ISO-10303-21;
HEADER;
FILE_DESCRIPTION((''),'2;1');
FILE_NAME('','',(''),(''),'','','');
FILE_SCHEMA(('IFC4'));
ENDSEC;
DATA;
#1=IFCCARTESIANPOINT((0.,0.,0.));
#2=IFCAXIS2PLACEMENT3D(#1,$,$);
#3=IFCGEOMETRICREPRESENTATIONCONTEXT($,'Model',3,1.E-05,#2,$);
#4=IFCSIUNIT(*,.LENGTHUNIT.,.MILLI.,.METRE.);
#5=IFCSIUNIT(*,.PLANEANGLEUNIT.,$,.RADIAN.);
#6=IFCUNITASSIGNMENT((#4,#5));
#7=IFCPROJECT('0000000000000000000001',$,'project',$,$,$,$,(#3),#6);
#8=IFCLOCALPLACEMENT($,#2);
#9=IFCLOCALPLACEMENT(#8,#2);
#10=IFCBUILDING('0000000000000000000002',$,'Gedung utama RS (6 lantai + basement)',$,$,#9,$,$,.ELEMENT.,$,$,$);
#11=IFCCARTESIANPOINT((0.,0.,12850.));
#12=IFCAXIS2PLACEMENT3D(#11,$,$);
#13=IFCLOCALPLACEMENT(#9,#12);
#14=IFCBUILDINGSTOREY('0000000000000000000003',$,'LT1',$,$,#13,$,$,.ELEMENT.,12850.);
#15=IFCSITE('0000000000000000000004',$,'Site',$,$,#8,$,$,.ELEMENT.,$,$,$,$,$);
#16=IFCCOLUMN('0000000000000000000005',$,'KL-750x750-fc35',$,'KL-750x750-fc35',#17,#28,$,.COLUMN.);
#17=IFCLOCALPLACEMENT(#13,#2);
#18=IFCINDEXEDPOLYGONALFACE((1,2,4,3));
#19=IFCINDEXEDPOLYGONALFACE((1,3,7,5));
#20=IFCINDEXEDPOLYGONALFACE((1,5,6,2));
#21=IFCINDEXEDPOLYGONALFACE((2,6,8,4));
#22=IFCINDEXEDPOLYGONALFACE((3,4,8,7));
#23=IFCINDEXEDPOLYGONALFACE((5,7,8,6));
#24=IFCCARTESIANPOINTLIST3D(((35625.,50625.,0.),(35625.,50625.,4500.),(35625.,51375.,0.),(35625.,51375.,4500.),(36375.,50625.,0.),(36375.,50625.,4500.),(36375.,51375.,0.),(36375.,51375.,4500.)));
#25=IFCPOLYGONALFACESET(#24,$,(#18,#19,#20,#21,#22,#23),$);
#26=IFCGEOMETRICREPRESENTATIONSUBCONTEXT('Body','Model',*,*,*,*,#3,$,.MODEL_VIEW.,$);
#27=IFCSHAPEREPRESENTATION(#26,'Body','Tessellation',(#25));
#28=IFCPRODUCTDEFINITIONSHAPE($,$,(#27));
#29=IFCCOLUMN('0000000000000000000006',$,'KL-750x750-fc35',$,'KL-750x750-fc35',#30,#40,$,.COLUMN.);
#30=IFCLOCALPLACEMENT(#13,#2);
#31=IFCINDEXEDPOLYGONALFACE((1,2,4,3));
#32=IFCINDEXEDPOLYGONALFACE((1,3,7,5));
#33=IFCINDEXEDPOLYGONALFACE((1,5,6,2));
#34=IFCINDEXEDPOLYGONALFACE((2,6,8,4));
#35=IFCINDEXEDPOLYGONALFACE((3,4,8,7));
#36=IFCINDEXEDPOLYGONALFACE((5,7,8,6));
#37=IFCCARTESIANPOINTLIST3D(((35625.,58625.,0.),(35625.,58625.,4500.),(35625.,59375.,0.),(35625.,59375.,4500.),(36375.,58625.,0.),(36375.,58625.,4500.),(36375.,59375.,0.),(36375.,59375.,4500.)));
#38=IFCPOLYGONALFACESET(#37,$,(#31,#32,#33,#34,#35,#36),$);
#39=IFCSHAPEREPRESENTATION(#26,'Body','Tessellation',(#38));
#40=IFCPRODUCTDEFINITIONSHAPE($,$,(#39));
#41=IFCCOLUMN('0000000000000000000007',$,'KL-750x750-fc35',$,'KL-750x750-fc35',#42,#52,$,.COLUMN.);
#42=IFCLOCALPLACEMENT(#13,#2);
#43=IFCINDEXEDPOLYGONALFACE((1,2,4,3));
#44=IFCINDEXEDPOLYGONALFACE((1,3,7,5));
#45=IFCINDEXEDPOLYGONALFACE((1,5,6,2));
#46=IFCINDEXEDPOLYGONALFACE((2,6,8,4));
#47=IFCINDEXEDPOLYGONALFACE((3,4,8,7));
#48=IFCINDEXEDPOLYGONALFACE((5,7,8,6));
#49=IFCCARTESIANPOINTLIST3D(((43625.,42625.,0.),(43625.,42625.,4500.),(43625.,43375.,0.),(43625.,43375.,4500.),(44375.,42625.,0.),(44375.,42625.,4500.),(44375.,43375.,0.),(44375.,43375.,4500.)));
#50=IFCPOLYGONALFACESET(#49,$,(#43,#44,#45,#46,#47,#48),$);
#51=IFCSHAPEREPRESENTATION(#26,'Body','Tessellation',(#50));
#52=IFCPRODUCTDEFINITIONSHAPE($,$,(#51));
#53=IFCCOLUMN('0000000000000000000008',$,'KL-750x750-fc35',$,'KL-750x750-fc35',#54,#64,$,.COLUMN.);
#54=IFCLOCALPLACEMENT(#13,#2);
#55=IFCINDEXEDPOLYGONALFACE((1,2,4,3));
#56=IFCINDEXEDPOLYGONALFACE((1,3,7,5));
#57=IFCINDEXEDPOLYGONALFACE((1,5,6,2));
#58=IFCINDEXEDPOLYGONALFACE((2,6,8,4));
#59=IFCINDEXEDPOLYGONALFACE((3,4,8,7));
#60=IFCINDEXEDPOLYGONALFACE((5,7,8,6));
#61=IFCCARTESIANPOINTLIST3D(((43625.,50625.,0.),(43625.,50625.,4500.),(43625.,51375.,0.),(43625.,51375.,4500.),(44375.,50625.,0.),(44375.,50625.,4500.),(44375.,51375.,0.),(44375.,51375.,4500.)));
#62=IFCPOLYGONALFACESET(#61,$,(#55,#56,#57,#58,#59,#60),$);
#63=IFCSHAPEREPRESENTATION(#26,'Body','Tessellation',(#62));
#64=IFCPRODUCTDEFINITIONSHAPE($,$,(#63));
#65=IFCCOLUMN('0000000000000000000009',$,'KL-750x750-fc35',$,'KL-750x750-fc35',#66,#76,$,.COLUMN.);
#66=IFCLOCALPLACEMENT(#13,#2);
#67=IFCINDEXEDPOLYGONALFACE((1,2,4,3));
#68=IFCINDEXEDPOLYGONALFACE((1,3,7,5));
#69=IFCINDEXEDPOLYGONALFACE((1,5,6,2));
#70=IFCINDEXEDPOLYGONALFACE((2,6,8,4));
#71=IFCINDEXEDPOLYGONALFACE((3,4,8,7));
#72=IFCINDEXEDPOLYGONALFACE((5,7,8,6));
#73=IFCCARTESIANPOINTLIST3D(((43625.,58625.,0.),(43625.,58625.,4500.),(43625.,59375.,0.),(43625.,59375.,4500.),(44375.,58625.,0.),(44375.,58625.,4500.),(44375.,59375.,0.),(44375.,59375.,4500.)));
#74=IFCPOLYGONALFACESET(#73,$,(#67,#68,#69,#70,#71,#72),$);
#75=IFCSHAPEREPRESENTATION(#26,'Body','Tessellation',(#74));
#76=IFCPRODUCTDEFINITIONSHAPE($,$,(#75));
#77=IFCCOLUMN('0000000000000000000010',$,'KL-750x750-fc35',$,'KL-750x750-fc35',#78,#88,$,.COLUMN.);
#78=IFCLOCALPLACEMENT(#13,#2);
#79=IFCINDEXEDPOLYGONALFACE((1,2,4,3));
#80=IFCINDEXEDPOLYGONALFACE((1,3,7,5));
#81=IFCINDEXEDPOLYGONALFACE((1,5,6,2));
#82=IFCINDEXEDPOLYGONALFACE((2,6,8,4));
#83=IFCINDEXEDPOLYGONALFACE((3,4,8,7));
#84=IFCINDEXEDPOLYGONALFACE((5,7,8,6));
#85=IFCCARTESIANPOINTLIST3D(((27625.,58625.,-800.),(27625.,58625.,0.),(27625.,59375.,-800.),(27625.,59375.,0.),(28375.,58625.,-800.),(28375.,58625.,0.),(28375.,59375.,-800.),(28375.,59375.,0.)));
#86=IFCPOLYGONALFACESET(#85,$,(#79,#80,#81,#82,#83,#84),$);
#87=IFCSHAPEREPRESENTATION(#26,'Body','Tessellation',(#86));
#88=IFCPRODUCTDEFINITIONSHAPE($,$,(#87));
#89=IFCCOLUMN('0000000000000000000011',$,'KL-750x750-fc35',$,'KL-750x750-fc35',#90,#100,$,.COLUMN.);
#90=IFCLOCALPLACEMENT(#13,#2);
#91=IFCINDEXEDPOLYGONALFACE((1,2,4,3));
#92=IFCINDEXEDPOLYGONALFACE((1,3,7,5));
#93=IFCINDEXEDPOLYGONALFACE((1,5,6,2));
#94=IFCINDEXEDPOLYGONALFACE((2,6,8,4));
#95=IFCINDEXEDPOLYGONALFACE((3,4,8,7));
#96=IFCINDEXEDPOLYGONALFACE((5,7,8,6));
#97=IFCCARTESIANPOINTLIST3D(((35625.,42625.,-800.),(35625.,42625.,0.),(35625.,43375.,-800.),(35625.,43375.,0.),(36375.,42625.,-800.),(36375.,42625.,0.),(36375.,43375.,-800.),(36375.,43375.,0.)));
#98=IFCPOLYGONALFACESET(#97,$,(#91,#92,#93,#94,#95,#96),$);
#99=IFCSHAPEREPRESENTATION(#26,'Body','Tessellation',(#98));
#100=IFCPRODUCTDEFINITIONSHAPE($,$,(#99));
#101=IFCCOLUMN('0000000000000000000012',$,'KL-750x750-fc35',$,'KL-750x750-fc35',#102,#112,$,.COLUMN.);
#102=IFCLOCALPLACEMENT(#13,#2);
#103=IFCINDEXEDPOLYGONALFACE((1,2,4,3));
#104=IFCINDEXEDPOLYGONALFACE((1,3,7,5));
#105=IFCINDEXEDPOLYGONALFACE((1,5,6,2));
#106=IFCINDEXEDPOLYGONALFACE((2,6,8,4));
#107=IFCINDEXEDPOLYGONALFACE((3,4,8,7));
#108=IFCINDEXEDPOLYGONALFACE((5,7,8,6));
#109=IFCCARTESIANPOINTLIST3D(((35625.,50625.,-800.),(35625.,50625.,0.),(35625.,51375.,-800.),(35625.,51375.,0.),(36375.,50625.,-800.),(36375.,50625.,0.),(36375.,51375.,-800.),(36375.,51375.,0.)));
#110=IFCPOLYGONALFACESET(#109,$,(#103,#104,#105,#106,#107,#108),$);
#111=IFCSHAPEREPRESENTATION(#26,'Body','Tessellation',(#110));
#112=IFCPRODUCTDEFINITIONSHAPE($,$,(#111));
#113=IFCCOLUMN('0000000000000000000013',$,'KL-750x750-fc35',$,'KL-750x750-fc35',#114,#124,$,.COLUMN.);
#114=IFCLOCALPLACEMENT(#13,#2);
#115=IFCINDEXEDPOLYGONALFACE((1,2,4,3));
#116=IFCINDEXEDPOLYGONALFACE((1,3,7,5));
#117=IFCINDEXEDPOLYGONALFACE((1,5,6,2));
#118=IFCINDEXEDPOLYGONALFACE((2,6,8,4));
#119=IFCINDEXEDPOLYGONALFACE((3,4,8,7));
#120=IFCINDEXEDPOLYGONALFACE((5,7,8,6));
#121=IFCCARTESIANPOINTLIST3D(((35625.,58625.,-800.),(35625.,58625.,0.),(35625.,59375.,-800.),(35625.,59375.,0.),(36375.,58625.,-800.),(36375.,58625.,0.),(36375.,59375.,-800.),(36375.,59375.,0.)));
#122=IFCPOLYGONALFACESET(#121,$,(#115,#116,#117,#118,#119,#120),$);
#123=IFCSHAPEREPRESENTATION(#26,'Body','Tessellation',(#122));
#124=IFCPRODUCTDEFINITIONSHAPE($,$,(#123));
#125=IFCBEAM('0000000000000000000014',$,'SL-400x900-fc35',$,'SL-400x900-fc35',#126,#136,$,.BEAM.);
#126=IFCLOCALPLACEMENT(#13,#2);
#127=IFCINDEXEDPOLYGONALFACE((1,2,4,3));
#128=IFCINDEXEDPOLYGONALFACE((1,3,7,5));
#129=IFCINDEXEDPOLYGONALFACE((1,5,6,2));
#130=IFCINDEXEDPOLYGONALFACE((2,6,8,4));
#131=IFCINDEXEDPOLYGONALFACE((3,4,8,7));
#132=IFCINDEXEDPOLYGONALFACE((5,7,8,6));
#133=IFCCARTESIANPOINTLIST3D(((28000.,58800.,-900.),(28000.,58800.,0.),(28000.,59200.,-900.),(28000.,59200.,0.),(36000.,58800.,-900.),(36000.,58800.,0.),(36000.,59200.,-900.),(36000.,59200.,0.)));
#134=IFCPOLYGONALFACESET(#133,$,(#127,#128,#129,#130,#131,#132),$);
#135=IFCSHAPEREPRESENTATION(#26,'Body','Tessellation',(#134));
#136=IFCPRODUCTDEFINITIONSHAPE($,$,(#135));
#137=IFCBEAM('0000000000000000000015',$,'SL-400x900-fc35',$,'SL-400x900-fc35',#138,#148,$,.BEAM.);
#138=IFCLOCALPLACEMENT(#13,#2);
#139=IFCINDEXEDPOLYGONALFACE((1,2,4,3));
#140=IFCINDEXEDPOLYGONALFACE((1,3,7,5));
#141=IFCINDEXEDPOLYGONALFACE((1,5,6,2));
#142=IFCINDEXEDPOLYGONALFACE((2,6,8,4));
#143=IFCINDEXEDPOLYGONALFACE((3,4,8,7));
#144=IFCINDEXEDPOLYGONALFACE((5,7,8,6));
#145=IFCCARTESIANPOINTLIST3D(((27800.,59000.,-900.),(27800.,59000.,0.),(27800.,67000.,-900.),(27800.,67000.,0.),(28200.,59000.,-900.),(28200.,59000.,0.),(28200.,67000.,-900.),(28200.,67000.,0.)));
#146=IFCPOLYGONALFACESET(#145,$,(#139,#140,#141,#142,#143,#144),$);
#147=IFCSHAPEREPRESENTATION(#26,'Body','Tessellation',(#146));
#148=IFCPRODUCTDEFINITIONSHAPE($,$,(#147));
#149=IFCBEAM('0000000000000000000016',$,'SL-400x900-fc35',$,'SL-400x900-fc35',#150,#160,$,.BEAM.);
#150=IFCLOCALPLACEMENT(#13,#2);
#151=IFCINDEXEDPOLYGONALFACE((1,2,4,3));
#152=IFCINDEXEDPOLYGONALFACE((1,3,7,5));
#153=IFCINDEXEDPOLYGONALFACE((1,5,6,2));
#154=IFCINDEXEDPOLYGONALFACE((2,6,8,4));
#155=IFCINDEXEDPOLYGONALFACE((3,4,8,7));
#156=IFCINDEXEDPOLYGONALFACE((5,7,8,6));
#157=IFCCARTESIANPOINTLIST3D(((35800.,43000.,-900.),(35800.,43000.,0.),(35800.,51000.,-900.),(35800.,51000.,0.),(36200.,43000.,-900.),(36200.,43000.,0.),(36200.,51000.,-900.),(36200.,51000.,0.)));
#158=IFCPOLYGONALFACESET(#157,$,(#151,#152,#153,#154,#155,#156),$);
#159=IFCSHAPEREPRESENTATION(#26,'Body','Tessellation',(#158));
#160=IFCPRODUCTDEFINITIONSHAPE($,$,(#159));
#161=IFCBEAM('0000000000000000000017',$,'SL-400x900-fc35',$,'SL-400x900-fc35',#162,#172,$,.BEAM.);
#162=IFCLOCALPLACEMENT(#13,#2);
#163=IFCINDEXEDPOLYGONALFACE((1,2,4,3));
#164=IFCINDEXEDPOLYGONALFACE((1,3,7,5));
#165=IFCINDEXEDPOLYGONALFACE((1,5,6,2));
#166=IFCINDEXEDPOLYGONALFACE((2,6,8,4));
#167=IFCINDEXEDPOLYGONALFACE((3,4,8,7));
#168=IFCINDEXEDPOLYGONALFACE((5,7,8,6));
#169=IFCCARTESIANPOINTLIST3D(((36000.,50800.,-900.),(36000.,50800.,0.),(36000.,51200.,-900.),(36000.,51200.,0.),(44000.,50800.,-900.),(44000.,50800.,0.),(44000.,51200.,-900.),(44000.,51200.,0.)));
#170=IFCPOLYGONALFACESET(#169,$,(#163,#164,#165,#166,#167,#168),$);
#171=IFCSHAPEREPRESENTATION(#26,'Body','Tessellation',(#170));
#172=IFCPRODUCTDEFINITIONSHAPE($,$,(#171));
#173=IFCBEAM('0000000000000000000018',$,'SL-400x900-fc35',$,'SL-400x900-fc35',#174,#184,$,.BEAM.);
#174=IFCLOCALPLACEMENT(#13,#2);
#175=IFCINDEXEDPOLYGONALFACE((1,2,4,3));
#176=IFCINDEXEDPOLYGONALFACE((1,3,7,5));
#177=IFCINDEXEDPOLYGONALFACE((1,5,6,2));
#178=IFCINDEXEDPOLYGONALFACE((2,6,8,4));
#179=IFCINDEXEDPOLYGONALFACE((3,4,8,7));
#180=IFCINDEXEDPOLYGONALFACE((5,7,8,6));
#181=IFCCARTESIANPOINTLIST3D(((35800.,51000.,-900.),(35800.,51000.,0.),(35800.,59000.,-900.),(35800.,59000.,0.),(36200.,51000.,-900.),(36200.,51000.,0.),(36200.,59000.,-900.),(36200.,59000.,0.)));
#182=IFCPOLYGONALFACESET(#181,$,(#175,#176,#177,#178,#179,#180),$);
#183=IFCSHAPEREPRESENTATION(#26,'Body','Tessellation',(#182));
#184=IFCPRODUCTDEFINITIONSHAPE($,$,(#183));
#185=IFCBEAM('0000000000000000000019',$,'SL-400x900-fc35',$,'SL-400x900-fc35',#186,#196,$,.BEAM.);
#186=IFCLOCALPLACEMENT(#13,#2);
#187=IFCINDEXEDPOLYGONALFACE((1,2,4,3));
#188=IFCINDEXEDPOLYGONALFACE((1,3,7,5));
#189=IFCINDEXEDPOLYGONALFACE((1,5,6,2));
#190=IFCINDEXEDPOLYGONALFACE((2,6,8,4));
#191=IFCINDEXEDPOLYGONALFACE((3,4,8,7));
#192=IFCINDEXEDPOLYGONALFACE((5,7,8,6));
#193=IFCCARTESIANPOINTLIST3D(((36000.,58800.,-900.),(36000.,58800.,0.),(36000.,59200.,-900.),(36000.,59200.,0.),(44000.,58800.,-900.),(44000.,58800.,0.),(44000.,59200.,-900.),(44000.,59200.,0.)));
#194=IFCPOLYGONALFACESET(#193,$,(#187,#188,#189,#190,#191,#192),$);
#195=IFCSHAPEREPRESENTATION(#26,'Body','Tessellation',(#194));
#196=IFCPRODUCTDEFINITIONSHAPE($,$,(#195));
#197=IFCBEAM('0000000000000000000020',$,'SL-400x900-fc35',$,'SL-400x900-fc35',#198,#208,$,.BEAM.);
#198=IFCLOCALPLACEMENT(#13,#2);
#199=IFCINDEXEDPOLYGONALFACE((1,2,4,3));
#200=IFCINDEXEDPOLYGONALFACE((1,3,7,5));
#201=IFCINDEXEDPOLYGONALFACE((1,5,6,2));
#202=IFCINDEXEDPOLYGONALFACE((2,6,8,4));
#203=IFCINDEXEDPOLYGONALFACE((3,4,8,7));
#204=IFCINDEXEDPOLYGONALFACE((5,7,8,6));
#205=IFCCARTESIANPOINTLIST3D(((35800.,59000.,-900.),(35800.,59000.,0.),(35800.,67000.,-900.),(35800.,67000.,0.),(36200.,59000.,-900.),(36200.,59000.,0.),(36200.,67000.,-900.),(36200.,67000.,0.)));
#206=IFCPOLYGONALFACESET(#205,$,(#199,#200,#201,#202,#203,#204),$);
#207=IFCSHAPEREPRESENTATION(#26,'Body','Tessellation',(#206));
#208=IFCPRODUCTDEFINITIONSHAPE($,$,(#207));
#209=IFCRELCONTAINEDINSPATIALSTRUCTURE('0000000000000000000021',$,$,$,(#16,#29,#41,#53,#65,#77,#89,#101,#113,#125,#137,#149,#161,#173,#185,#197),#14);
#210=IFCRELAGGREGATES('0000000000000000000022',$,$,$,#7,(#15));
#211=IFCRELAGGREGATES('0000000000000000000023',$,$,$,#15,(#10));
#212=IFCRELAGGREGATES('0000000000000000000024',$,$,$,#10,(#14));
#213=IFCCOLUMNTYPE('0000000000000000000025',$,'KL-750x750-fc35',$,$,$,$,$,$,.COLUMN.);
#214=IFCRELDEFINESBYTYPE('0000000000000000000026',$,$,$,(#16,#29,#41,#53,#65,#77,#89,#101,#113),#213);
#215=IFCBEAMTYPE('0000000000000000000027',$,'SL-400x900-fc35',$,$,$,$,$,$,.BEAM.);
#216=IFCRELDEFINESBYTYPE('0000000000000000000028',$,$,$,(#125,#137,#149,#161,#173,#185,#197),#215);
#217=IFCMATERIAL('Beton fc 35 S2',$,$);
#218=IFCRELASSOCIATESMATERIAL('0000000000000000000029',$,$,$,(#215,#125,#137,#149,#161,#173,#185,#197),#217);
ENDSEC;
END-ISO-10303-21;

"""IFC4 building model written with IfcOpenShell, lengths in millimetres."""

from ifc_helpers import new_model, si_unit, frame, origin, origin_2d, place, context, subcontext, project, spatial, rectangle, extrude, material, material_profile, profile_set, profile_usage, type_object, element, save


model = new_model("IFC4")

# Units and contexts
model_context = context("Model", 3, precision=1e-05, world=origin())
body_context = subcontext(model_context, "Body", "Model", "MODEL_VIEW")
ifc_project = project(units=[si_unit("LENGTHUNIT", "METRE", prefix="MILLI"), si_unit("PLANEANGLEUNIT", "RADIAN")], contexts=[model_context])

# Site, building, storey
site_placement = place(None, origin())
site = spatial("IfcSite", under=ifc_project, at=site_placement, Name="Site", CompositionType="ELEMENT")
building_placement = place(site_placement, origin())
building = spatial("IfcBuilding", under=site, at=building_placement, Name="Gedung utama RS (6 lantai + basement)", CompositionType="ELEMENT")
storey_placement = place(building_placement, frame((0.0, 0.0, 12850.0)))
storey = spatial("IfcBuildingStorey", under=building, at=storey_placement, Name="LT1", CompositionType="ELEMENT", Elevation=12850.0)

# Columns
ifc_material_profile_1 = material_profile(None, rectangle(XDim=750.0, YDim=750.0, at=origin_2d()), Name="KL-750x750-fc35")
ifc_profile_set_1 = profile_set([ifc_material_profile_1], Name="KL-750x750-fc35")
ifc_profile_usage_1 = profile_usage(ifc_profile_set_1, cardinal=5)
column_type = type_object("IfcColumnType", Name="KL-750x750-fc35", PredefinedType="COLUMN", material=ifc_profile_set_1)
for number, where, z_axis, x_axis, name in (
    (1, (36000.0, 51000.0, 0.0), (0.0, 0.0, 1.0), (1.0, 0.0, 0.0), "KL-750x750-fc35"),
    (2, (36000.0, 59000.0, 0.0), (0.0, 0.0, 1.0), (1.0, 0.0, 0.0), "KL-750x750-fc35"),
    (3, (44000.0, 43000.0, 0.0), (0.0, 0.0, 1.0), (1.0, 0.0, 0.0), "KL-750x750-fc35"),
    (4, (44000.0, 51000.0, 0.0), (0.0, 0.0, 1.0), (1.0, 0.0, 0.0), "KL-750x750-fc35"),
    (5, (44000.0, 59000.0, 0.0), (0.0, 0.0, 1.0), (1.0, 0.0, 0.0), "KL-750x750-fc35"),
):
    element("IfcColumn", number, at=place(storey_placement, frame(where, z_axis=z_axis, x_axis=x_axis)), inside=storey, type_object=column_type, material=ifc_profile_usage_1, Name=name, ObjectType="KL-750x750-fc35", PredefinedType="COLUMN", context=body_context, shape_type="SweptSolid", body=[
        extrude(rectangle(XDim=750.0, YDim=750.0, at=origin_2d()), origin(), (0.0, 0.0, 1.0), 4500.0),
    ])
for number, where, z_axis, x_axis, name in (
    (6, (28000.0, 59000.0, -800.0), (0.0, 0.0, 1.0), (1.0, 0.0, 0.0), "KL-750x750-fc35"),
    (7, (36000.0, 43000.0, -800.0), (0.0, 0.0, 1.0), (1.0, 0.0, 0.0), "KL-750x750-fc35"),
    (8, (36000.0, 51000.0, -800.0), (0.0, 0.0, 1.0), (1.0, 0.0, 0.0), "KL-750x750-fc35"),
    (9, (36000.0, 59000.0, -800.0), (0.0, 0.0, 1.0), (1.0, 0.0, 0.0), "KL-750x750-fc35"),
):
    element("IfcColumn", number, at=place(storey_placement, frame(where, z_axis=z_axis, x_axis=x_axis)), inside=storey, type_object=column_type, material=ifc_profile_usage_1, Name=name, ObjectType="KL-750x750-fc35", PredefinedType="COLUMN", context=body_context, shape_type="SweptSolid", body=[
        extrude(rectangle(XDim=750.0, YDim=750.0, at=origin_2d()), origin(), (0.0, 0.0, 1.0), 800.0),
    ])

# Beams
ifc_material = material(Name="Beton fc 35 S2")
ifc_material_profile_2 = material_profile(ifc_material, rectangle(XDim=400.0, YDim=900.0, at=origin_2d()), Name="SL-400x900-fc35")
ifc_profile_set_2 = profile_set([ifc_material_profile_2], Name="SL-400x900-fc35")
ifc_profile_usage_2 = profile_usage(ifc_profile_set_2, cardinal=8)
beam_type = type_object("IfcBeamType", Name="SL-400x900-fc35", PredefinedType="BEAM", material=ifc_profile_set_2)
beam_1_placement = place(storey_placement, frame((28000.0, 59000.0, -450.0)))
element("IfcBeam", 10, at=beam_1_placement, inside=storey, type_object=beam_type, material=ifc_profile_usage_2, Name="SL-400x900-fc35", ObjectType="SL-400x900-fc35", PredefinedType="BEAM", context=body_context, shape_type="SweptSolid", body=[
    extrude(rectangle(XDim=400.0, YDim=900.0, at=origin_2d()), frame((0.0, 0.0, 0.0), z_axis=(1.0, 0.0, 0.0), x_axis=(0.0, 1.0, 0.0)), (0.0, 0.0, 1.0), 8000.0),
])
for number, where, name in (
    (11, (28000.0, 59000.0, -450.0), "SL-400x900-fc35"),
    (12, (36000.0, 43000.0, -450.0), "SL-400x900-fc35"),
):
    element("IfcBeam", number, at=place(storey_placement, frame(where)), inside=storey, type_object=beam_type, material=ifc_profile_usage_2, Name=name, ObjectType="SL-400x900-fc35", PredefinedType="BEAM", context=body_context, shape_type="SweptSolid", body=[
        extrude(rectangle(XDim=400.0, YDim=900.0, at=origin_2d()), frame((0.0, 0.0, 0.0), z_axis=(0.0, 1.0, 0.0), x_axis=(-1.0, 0.0, 0.0)), (0.0, 0.0, 1.0), 8000.0),
    ])
beam_2_placement = place(storey_placement, frame((36000.0, 51000.0, -450.0)))
element("IfcBeam", 13, at=beam_2_placement, inside=storey, type_object=beam_type, material=ifc_profile_usage_2, Name="SL-400x900-fc35", ObjectType="SL-400x900-fc35", PredefinedType="BEAM", context=body_context, shape_type="SweptSolid", body=[
    extrude(rectangle(XDim=400.0, YDim=900.0, at=origin_2d()), frame((0.0, 0.0, 0.0), z_axis=(1.0, 0.0, 0.0), x_axis=(0.0, 1.0, 0.0)), (0.0, 0.0, 1.0), 8000.0),
])
beam_3_placement = place(storey_placement, frame((36000.0, 51000.0, -450.0)))
element("IfcBeam", 14, at=beam_3_placement, inside=storey, type_object=beam_type, material=ifc_profile_usage_2, Name="SL-400x900-fc35", ObjectType="SL-400x900-fc35", PredefinedType="BEAM", context=body_context, shape_type="SweptSolid", body=[
    extrude(rectangle(XDim=400.0, YDim=900.0, at=origin_2d()), frame((0.0, 0.0, 0.0), z_axis=(0.0, 1.0, 0.0), x_axis=(-1.0, 0.0, 0.0)), (0.0, 0.0, 1.0), 8000.0),
])
beam_4_placement = place(storey_placement, frame((36000.0, 59000.0, -450.0)))
element("IfcBeam", 15, at=beam_4_placement, inside=storey, type_object=beam_type, material=ifc_profile_usage_2, Name="SL-400x900-fc35", ObjectType="SL-400x900-fc35", PredefinedType="BEAM", context=body_context, shape_type="SweptSolid", body=[
    extrude(rectangle(XDim=400.0, YDim=900.0, at=origin_2d()), frame((0.0, 0.0, 0.0), z_axis=(1.0, 0.0, 0.0), x_axis=(0.0, 1.0, 0.0)), (0.0, 0.0, 1.0), 8000.0),
])
beam_5_placement = place(storey_placement, frame((36000.0, 59000.0, -450.0)))
element("IfcBeam", 16, at=beam_5_placement, inside=storey, type_object=beam_type, material=ifc_profile_usage_2, Name="SL-400x900-fc35", ObjectType="SL-400x900-fc35", PredefinedType="BEAM", context=body_context, shape_type="SweptSolid", body=[
    extrude(rectangle(XDim=400.0, YDim=900.0, at=origin_2d()), frame((0.0, 0.0, 0.0), z_axis=(0.0, 1.0, 0.0), x_axis=(-1.0, 0.0, 0.0)), (0.0, 0.0, 1.0), 8000.0),
])

save(model, "model.ifc")
